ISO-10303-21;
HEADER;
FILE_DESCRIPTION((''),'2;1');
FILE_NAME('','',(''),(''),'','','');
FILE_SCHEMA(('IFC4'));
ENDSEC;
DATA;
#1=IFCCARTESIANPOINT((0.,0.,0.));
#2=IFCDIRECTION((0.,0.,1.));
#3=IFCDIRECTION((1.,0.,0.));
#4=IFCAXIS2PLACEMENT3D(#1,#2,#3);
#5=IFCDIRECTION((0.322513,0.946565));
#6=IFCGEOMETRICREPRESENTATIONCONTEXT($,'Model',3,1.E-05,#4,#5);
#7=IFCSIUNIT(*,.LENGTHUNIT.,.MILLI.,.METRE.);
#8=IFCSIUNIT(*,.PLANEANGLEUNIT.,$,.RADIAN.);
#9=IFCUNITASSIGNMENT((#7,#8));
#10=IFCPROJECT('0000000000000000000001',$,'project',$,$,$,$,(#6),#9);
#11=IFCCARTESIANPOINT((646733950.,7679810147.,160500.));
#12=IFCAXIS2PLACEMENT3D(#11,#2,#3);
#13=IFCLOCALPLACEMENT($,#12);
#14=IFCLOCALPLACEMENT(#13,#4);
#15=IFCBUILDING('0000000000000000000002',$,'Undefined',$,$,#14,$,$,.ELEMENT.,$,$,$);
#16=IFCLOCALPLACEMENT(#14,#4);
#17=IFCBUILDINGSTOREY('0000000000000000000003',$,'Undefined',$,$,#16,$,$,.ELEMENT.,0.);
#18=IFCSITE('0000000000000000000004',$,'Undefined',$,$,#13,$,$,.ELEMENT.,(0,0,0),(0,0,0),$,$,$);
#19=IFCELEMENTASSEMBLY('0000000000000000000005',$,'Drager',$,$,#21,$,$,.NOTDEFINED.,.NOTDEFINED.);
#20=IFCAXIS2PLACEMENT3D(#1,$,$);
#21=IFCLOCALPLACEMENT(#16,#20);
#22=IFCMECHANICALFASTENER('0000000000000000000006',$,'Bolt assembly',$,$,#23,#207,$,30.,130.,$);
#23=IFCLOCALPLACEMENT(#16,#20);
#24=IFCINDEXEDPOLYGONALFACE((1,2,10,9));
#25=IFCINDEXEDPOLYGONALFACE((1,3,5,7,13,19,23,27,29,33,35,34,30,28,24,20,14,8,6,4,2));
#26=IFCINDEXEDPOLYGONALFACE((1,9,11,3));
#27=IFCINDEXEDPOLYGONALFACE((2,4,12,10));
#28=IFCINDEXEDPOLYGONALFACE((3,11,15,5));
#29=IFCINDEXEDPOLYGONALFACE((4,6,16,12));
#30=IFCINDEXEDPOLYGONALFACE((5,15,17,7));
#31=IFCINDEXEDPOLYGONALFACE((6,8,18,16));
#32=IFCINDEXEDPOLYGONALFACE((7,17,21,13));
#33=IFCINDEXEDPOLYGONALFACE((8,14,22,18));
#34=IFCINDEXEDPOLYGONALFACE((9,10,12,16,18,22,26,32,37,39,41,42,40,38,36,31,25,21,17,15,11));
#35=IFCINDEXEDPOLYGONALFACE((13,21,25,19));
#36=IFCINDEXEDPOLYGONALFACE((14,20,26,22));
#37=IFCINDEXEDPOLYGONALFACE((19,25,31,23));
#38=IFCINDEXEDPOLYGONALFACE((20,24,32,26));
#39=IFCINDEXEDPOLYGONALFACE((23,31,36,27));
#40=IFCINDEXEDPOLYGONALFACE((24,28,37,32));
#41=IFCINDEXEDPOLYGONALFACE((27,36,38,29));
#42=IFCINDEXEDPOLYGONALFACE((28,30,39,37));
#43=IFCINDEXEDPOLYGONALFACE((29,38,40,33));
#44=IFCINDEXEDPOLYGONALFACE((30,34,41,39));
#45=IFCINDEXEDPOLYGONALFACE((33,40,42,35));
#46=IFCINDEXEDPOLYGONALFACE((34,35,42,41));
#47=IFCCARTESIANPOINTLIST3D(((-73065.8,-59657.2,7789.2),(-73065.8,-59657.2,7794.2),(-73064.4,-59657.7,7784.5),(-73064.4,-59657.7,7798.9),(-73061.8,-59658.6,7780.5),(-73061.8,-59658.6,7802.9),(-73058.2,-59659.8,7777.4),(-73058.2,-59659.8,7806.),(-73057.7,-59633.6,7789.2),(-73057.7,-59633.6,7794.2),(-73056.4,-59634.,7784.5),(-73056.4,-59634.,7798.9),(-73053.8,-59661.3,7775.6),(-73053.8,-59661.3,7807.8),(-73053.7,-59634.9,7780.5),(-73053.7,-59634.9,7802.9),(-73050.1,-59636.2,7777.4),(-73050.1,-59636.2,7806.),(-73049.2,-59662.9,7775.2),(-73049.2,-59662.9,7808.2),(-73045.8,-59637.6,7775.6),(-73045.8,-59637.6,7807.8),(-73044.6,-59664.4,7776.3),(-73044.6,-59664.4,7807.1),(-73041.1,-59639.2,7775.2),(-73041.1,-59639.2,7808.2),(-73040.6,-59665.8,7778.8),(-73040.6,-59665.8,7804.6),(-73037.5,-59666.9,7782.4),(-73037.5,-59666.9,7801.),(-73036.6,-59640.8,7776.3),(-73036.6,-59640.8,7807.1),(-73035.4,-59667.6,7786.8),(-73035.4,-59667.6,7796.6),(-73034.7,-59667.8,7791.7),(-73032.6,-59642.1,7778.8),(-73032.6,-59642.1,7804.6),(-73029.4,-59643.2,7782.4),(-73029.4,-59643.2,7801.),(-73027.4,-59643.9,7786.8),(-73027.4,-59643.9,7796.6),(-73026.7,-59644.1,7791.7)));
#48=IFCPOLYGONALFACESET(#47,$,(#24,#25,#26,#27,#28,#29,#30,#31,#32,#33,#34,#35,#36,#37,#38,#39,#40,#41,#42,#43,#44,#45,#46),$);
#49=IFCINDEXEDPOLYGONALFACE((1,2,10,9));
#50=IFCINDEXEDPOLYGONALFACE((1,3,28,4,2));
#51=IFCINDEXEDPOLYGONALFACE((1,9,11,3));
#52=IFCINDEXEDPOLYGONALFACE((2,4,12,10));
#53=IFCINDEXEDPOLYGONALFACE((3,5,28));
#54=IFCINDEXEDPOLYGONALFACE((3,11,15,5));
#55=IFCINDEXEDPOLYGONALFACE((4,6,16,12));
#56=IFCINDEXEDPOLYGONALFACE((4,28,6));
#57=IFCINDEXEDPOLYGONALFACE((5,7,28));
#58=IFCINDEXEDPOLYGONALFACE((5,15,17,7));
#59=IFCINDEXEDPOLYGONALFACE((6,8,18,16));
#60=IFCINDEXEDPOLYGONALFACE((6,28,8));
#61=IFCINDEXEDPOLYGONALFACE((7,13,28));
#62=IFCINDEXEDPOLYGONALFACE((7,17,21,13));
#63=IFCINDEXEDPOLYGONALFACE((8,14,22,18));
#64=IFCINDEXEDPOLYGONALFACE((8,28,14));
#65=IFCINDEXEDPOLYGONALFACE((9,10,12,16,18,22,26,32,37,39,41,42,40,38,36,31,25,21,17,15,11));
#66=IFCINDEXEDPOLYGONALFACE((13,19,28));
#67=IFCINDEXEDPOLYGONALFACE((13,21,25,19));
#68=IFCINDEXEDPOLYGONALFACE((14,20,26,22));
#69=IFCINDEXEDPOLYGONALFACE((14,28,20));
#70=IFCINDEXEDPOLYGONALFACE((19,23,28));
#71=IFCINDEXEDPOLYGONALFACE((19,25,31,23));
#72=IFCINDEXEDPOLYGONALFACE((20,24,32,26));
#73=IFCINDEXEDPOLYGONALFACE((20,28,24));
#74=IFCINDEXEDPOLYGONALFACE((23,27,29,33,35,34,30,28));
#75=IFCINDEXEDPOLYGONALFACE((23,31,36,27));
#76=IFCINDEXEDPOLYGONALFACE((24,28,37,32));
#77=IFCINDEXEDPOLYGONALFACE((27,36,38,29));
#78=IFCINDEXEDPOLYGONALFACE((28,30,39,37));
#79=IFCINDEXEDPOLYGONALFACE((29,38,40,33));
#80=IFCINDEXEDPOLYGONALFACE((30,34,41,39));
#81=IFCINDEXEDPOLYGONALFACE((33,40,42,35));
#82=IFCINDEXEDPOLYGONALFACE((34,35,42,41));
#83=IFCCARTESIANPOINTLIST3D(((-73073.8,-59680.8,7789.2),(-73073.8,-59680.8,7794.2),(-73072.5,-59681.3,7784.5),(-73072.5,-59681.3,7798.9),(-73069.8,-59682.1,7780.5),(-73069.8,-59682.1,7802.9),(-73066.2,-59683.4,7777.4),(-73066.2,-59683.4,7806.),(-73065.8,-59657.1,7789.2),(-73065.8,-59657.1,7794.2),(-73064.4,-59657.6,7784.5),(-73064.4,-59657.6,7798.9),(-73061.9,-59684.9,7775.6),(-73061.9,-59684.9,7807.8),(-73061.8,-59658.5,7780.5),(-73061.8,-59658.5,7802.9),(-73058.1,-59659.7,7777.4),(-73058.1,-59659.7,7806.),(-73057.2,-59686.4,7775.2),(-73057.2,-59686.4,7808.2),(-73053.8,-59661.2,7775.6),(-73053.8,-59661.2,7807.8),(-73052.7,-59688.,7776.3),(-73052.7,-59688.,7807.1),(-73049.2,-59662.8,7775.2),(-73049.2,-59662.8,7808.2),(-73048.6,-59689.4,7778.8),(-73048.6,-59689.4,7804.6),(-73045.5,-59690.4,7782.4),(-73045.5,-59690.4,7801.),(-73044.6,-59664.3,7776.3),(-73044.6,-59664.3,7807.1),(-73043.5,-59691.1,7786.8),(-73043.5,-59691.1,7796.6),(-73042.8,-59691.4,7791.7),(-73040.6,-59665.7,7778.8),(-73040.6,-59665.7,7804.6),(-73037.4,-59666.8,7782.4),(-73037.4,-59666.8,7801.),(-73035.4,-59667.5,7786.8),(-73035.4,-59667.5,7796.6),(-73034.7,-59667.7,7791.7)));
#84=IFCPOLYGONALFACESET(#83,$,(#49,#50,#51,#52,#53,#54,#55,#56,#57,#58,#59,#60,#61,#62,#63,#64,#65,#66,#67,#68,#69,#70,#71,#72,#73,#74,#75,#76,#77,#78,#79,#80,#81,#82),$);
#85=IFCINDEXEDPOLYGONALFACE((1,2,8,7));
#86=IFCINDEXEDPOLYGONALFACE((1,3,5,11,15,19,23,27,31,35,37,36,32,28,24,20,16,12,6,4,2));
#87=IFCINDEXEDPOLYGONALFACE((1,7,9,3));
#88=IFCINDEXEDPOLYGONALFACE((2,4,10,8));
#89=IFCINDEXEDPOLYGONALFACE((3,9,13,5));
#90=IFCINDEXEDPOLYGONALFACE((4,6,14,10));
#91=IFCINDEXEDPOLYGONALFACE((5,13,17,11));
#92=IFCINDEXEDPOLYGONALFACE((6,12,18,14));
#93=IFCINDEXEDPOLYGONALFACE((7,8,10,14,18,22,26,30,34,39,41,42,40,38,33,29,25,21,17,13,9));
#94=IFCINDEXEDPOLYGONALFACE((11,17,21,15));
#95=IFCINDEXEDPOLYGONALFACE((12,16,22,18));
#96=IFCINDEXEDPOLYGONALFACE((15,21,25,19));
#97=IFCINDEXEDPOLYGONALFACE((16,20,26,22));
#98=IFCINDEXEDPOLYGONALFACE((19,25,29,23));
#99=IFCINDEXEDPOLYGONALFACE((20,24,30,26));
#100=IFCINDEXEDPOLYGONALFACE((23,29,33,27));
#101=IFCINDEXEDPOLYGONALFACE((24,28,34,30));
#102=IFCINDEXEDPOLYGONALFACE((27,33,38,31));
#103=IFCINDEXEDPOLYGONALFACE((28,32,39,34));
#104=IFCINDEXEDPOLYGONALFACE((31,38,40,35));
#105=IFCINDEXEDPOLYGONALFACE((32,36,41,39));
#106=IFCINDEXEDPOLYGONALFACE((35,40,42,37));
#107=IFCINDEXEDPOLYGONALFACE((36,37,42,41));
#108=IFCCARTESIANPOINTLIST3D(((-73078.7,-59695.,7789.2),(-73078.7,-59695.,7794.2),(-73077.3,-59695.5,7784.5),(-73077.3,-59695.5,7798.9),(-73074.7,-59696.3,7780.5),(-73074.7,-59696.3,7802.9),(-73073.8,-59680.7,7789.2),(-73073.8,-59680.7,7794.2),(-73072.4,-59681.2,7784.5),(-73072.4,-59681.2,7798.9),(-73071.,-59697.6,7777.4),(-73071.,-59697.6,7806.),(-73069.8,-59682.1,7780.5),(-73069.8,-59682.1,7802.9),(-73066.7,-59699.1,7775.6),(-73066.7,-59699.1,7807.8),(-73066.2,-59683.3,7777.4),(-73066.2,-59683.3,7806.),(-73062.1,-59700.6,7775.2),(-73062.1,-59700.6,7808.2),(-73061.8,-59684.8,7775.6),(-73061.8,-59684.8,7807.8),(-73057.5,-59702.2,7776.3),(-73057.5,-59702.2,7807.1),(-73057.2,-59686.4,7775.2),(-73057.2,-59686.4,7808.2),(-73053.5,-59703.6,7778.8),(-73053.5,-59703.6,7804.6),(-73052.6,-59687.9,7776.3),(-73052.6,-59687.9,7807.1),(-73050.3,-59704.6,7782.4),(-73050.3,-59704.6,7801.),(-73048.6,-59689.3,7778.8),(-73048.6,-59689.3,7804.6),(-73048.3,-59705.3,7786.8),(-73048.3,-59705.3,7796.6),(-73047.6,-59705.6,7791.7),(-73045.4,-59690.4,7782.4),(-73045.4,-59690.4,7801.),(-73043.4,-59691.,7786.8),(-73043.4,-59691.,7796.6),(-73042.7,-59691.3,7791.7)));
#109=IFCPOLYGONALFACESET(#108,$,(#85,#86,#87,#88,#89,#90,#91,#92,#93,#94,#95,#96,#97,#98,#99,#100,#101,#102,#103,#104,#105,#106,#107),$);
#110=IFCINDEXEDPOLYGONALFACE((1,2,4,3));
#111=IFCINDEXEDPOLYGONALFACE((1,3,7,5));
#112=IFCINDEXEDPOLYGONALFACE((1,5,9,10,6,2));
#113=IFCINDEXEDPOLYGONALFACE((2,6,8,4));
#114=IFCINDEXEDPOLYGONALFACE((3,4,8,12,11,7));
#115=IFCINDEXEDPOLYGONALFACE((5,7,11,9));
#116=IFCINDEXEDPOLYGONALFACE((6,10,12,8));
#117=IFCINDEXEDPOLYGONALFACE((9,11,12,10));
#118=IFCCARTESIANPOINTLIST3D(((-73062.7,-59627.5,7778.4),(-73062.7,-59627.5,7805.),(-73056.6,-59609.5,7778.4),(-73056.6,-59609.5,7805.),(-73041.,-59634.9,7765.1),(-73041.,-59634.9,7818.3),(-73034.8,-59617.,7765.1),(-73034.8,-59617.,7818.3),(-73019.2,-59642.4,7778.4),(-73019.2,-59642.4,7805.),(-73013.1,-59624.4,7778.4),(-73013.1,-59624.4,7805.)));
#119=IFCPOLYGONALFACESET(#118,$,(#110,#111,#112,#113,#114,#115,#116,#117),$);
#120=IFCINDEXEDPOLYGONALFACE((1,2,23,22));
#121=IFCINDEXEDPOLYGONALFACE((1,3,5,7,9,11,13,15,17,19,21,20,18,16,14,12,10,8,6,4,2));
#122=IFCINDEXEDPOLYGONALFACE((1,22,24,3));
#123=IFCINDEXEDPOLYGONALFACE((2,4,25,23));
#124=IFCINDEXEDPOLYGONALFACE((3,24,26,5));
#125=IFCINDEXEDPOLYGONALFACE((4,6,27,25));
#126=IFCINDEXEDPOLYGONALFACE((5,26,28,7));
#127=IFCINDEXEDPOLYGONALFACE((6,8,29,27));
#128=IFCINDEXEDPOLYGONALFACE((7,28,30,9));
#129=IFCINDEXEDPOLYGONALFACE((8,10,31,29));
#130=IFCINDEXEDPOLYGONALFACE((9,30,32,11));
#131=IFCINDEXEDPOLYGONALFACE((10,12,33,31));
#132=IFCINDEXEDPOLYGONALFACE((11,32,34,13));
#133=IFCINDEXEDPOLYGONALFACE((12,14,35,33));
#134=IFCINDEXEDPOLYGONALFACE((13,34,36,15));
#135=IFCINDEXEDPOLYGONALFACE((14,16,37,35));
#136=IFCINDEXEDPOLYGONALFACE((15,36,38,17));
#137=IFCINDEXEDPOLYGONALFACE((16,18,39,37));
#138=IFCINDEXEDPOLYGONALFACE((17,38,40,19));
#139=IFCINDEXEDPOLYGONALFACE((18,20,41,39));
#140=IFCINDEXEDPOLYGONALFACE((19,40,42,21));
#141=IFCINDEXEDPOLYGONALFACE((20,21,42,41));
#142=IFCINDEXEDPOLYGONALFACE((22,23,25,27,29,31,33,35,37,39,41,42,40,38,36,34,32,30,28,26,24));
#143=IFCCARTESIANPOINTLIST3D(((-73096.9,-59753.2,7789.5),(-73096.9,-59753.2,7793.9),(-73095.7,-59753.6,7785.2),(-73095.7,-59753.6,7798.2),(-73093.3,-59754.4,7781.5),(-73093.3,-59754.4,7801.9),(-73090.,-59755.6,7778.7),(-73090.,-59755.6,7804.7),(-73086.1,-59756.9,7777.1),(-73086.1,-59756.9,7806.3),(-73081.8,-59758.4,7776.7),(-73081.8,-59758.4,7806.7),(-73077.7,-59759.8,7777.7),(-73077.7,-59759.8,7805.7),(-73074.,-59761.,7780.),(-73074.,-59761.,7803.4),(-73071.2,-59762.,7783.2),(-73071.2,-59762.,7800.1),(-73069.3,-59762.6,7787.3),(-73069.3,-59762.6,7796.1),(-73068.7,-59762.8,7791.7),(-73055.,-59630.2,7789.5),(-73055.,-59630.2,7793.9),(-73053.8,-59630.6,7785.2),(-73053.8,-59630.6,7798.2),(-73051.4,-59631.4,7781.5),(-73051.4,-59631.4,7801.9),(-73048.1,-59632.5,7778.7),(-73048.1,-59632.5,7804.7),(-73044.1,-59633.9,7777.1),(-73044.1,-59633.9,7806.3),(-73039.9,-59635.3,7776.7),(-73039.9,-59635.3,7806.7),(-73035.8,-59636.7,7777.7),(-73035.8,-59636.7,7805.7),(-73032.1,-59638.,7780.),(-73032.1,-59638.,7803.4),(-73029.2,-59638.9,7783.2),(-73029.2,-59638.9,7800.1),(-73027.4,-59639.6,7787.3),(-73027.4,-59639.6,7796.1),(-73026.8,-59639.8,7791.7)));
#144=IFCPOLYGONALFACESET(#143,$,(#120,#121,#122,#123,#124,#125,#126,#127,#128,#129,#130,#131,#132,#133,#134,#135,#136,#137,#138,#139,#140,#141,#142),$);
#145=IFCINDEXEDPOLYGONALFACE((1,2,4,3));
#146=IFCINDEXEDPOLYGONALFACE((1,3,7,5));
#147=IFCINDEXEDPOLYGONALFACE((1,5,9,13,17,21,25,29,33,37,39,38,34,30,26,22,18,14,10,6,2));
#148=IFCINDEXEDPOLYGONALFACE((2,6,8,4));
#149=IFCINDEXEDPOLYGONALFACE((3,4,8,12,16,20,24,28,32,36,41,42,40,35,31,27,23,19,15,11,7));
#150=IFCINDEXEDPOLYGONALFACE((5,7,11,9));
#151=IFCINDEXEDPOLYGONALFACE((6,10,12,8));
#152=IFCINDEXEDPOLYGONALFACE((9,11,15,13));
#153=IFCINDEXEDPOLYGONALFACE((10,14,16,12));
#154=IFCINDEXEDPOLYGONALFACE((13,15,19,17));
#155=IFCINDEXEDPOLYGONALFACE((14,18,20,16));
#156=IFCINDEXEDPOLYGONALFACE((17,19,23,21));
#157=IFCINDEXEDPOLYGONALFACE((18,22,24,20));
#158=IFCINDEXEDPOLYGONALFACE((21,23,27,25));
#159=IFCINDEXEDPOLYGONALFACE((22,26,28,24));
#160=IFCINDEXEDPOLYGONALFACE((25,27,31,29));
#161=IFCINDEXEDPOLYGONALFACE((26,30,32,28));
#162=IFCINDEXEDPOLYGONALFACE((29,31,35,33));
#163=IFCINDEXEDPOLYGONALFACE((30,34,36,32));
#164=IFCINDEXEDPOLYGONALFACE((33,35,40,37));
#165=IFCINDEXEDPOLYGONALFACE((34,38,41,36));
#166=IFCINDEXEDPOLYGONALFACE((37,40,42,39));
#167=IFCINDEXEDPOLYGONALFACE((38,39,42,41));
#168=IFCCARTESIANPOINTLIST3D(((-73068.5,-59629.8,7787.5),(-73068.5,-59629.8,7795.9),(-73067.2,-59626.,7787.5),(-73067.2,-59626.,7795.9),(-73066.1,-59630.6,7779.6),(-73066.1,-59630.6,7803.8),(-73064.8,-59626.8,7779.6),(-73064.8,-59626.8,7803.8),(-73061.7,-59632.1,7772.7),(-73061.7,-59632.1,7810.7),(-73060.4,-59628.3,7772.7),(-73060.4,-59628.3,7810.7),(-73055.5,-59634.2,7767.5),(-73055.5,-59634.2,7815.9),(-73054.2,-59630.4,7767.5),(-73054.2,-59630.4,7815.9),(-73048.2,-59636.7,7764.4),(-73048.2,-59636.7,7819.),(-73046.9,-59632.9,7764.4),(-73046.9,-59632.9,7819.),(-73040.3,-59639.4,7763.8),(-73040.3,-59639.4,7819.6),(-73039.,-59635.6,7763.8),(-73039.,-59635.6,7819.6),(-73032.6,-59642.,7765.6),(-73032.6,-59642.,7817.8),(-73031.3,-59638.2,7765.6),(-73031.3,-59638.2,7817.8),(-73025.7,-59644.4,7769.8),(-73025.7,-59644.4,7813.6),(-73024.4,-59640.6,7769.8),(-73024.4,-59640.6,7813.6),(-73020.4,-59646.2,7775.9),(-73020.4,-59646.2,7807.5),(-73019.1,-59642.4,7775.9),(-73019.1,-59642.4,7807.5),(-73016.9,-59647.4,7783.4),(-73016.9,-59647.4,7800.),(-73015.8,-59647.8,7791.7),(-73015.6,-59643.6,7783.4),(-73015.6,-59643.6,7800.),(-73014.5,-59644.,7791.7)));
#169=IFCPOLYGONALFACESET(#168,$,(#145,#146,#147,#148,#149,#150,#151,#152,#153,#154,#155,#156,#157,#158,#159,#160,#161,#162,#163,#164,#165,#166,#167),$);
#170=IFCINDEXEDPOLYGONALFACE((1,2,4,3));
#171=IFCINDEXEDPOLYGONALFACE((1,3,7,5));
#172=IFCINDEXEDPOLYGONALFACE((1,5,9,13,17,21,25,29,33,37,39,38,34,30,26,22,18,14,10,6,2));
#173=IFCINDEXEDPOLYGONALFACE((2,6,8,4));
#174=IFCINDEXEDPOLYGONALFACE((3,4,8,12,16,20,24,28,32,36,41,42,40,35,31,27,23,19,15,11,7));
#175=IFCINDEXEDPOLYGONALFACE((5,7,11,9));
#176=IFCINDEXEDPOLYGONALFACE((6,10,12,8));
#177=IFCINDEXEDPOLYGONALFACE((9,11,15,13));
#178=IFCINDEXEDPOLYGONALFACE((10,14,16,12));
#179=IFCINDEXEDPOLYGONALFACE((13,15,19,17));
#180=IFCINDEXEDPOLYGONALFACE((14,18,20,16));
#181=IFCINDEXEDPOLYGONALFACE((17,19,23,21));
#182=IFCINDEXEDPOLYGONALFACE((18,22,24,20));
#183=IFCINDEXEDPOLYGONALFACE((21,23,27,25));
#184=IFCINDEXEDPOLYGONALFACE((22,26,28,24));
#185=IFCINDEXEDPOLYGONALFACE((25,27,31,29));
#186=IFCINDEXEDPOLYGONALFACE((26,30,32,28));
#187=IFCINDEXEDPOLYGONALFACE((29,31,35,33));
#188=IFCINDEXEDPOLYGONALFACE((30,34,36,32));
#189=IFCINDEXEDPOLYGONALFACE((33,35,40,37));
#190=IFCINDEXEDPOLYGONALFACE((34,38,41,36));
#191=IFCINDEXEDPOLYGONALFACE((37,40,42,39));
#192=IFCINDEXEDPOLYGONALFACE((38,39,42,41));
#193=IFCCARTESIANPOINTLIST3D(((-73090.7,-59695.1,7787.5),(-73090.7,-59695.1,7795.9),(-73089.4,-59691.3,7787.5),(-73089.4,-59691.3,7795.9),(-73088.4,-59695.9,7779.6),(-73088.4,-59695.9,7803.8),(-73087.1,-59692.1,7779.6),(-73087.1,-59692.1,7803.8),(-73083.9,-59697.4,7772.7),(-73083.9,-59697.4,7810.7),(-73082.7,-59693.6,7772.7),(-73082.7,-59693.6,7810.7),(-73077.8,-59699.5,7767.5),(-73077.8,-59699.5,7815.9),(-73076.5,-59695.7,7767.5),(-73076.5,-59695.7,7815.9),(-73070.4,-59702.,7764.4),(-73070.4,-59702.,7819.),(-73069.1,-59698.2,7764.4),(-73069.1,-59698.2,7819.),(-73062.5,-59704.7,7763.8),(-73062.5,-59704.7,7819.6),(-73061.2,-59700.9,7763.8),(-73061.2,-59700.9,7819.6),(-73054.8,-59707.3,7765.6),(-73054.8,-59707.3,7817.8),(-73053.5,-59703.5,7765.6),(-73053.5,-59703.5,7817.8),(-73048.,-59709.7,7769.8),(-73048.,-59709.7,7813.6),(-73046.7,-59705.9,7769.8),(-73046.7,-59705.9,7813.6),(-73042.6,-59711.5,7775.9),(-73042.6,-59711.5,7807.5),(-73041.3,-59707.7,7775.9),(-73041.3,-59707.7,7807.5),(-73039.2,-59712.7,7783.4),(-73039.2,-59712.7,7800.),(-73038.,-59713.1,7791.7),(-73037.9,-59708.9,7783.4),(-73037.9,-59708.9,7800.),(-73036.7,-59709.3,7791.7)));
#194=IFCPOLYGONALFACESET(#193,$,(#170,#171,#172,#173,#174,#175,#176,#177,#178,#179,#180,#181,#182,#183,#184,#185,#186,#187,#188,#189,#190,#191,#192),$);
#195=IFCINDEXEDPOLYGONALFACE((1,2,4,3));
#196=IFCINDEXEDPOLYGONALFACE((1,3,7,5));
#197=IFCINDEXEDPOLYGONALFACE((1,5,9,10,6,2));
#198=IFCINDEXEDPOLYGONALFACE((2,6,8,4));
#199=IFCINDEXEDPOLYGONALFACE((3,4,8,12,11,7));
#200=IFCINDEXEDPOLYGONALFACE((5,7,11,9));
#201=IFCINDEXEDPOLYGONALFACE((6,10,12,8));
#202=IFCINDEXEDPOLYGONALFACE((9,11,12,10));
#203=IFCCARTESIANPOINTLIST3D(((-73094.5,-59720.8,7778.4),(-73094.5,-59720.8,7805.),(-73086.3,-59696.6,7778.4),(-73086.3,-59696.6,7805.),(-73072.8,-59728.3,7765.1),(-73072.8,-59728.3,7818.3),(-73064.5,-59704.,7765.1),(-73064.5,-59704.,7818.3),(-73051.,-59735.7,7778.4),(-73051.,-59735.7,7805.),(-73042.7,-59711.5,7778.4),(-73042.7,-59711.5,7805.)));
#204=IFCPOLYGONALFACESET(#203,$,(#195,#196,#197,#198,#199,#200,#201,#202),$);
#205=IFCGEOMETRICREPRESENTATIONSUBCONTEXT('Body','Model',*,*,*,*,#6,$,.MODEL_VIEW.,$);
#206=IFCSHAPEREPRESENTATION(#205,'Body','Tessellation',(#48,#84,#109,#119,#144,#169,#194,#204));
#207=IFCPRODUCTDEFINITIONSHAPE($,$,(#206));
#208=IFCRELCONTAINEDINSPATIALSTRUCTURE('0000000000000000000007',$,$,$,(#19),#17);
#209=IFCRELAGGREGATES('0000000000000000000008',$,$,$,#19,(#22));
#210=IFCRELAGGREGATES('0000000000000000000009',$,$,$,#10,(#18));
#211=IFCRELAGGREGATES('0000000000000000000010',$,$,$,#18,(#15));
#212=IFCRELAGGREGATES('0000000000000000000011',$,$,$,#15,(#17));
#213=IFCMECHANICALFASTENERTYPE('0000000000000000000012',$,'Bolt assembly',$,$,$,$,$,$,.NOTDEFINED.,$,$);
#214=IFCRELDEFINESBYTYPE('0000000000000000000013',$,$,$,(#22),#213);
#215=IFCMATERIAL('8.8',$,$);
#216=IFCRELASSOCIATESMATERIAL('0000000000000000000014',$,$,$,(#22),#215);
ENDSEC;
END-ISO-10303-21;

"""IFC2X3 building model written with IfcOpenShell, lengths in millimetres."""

from ifc_helpers import new_model, si_unit, direction, frame, origin_with_axes, origin_2d_with_axis, place, context, subcontext, project, spatial, polyline, circle, outline, extrude, source, transform, mapped, material, type_object, element, aggregate, save


model = new_model("IFC2X3")

# Units and contexts
model_context = context("Model", 3, precision=1e-05, world=origin_with_axes(), true_north=direction((0.322513, 0.946565)))
body_context = subcontext(model_context, "Body", "Model", "MODEL_VIEW")
ifc_project = project(units=[si_unit("LENGTHUNIT", "METRE", prefix="MILLI"), si_unit("PLANEANGLEUNIT", "RADIAN")], contexts=[model_context])

# Site, building, storey
site_placement = place(None, frame((646733950.0, 7679810147.0, 160500.0), z_axis=(0.0, 0.0, 1.0), x_axis=(1.0, 0.0, 0.0)))
site = spatial("IfcSite", under=ifc_project, at=site_placement, Name="Undefined", CompositionType="ELEMENT", RefLatitude=(0, 0, 0), RefLongitude=(0, 0, 0))
building_placement = place(site_placement, origin_with_axes())
building = spatial("IfcBuilding", under=site, at=building_placement, Name="Undefined", CompositionType="ELEMENT")
storey_placement = place(building_placement, origin_with_axes())
storey = spatial("IfcBuildingStorey", under=building, at=storey_placement, Name="Undefined", CompositionType="ELEMENT", Elevation=0.0)

# Element assembly
assembly_1_placement = place(storey_placement, origin_with_axes())
assembly_1 = element("IfcElementAssembly", 1, at=assembly_1_placement, inside=storey, Name="Drager", AssemblyPlace="NOTDEFINED", PredefinedType="NOTDEFINED")

# Mechanical fastener
ifc_material_1 = material(Name="8.8")
mechanical_fastener_type = type_object("IfcMechanicalFastenerType", Name="Bolt assembly")
shared_shape_1 = source(origin_with_axes(), body_context, "Body", "SweptSolid", [
    extrude(circle(Radius=16.5, at=origin_2d_with_axis()), frame((0.0, -57.4, 0.0), z_axis=(0.0, 1.0, 0.0), x_axis=(1.0, 0.0, 0.0)), (0.0, 0.0, 1.0), 25.0),
    extrude(circle(Radius=16.5, at=origin_2d_with_axis()), frame((0.0, -32.5, 0.0), z_axis=(0.0, 1.0, 0.0), x_axis=(1.0, 0.0, 0.0)), (0.0, 0.0, 1.0), 25.0),
    extrude(circle(Radius=16.5, at=origin_2d_with_axis()), frame((0.0, -7.6, 0.0), z_axis=(0.0, 1.0, 0.0), x_axis=(1.0, 0.0, 0.0)), (0.0, 0.0, 1.0), 15.1),
    extrude(outline(polyline([(23.0, -13.3), (23.0, 13.3), (0.0, 26.6), (-23.0, 13.3), (-23.0, -13.3), (0.0, -26.6), (23.0, -13.3)])), frame((0.0, -80.5, 0.0), z_axis=(0.0, 1.0, 0.0), x_axis=(1.0, 0.0, 0.0)), (0.0, 0.0, 1.0), 19.0),
    extrude(circle(Radius=15.0, at=origin_2d_with_axis()), frame((0.0, -61.5, 0.0), z_axis=(0.0, 1.0, 0.0), x_axis=(1.0, 0.0, 0.0)), (0.0, 0.0, 1.0), 130.0),
    extrude(circle(Radius=28.0, at=origin_2d_with_axis()), frame((0.0, -61.5, 0.0), z_axis=(0.0, 1.0, 0.0), x_axis=(1.0, 0.0, 0.0)), (0.0, 0.0, 1.0), 4.0),
    extrude(circle(Radius=28.0, at=origin_2d_with_axis()), frame((0.0, 7.5, 0.0), z_axis=(0.0, 1.0, 0.0), x_axis=(1.0, 0.0, 0.0)), (0.0, 0.0, 1.0), 4.0),
    extrude(outline(polyline([(23.0, -13.3), (23.0, 13.3), (0.0, 26.6), (-23.0, 13.3), (-23.0, -13.3), (0.0, -26.6), (23.0, -13.3)])), frame((0.0, 11.5, 0.0), z_axis=(0.0, 1.0, 0.0), x_axis=(1.0, 0.0, 0.0)), (0.0, 0.0, 1.0), 25.6),
])
mechanical_fastener_1_placement = place(assembly_1_placement, frame((-73060.8, -59693.2, 7791.7), z_axis=(0.0, 0.0, -1.0), x_axis=(0.946565, -0.322513, 0.0)))
mechanical_fastener_1 = element("IfcMechanicalFastener", 2, at=mechanical_fastener_1_placement, type_object=mechanical_fastener_type, material=ifc_material_1, Name="Bolt assembly", NominalDiameter=30.0, NominalLength=130.0, context=body_context, shape_type="MappedRepresentation", body=[
    mapped(shared_shape_1, transform((0.0, 0.0, 0.0))),
])
aggregate(assembly_1, [mechanical_fastener_1])

save(model, "model.ifc")
